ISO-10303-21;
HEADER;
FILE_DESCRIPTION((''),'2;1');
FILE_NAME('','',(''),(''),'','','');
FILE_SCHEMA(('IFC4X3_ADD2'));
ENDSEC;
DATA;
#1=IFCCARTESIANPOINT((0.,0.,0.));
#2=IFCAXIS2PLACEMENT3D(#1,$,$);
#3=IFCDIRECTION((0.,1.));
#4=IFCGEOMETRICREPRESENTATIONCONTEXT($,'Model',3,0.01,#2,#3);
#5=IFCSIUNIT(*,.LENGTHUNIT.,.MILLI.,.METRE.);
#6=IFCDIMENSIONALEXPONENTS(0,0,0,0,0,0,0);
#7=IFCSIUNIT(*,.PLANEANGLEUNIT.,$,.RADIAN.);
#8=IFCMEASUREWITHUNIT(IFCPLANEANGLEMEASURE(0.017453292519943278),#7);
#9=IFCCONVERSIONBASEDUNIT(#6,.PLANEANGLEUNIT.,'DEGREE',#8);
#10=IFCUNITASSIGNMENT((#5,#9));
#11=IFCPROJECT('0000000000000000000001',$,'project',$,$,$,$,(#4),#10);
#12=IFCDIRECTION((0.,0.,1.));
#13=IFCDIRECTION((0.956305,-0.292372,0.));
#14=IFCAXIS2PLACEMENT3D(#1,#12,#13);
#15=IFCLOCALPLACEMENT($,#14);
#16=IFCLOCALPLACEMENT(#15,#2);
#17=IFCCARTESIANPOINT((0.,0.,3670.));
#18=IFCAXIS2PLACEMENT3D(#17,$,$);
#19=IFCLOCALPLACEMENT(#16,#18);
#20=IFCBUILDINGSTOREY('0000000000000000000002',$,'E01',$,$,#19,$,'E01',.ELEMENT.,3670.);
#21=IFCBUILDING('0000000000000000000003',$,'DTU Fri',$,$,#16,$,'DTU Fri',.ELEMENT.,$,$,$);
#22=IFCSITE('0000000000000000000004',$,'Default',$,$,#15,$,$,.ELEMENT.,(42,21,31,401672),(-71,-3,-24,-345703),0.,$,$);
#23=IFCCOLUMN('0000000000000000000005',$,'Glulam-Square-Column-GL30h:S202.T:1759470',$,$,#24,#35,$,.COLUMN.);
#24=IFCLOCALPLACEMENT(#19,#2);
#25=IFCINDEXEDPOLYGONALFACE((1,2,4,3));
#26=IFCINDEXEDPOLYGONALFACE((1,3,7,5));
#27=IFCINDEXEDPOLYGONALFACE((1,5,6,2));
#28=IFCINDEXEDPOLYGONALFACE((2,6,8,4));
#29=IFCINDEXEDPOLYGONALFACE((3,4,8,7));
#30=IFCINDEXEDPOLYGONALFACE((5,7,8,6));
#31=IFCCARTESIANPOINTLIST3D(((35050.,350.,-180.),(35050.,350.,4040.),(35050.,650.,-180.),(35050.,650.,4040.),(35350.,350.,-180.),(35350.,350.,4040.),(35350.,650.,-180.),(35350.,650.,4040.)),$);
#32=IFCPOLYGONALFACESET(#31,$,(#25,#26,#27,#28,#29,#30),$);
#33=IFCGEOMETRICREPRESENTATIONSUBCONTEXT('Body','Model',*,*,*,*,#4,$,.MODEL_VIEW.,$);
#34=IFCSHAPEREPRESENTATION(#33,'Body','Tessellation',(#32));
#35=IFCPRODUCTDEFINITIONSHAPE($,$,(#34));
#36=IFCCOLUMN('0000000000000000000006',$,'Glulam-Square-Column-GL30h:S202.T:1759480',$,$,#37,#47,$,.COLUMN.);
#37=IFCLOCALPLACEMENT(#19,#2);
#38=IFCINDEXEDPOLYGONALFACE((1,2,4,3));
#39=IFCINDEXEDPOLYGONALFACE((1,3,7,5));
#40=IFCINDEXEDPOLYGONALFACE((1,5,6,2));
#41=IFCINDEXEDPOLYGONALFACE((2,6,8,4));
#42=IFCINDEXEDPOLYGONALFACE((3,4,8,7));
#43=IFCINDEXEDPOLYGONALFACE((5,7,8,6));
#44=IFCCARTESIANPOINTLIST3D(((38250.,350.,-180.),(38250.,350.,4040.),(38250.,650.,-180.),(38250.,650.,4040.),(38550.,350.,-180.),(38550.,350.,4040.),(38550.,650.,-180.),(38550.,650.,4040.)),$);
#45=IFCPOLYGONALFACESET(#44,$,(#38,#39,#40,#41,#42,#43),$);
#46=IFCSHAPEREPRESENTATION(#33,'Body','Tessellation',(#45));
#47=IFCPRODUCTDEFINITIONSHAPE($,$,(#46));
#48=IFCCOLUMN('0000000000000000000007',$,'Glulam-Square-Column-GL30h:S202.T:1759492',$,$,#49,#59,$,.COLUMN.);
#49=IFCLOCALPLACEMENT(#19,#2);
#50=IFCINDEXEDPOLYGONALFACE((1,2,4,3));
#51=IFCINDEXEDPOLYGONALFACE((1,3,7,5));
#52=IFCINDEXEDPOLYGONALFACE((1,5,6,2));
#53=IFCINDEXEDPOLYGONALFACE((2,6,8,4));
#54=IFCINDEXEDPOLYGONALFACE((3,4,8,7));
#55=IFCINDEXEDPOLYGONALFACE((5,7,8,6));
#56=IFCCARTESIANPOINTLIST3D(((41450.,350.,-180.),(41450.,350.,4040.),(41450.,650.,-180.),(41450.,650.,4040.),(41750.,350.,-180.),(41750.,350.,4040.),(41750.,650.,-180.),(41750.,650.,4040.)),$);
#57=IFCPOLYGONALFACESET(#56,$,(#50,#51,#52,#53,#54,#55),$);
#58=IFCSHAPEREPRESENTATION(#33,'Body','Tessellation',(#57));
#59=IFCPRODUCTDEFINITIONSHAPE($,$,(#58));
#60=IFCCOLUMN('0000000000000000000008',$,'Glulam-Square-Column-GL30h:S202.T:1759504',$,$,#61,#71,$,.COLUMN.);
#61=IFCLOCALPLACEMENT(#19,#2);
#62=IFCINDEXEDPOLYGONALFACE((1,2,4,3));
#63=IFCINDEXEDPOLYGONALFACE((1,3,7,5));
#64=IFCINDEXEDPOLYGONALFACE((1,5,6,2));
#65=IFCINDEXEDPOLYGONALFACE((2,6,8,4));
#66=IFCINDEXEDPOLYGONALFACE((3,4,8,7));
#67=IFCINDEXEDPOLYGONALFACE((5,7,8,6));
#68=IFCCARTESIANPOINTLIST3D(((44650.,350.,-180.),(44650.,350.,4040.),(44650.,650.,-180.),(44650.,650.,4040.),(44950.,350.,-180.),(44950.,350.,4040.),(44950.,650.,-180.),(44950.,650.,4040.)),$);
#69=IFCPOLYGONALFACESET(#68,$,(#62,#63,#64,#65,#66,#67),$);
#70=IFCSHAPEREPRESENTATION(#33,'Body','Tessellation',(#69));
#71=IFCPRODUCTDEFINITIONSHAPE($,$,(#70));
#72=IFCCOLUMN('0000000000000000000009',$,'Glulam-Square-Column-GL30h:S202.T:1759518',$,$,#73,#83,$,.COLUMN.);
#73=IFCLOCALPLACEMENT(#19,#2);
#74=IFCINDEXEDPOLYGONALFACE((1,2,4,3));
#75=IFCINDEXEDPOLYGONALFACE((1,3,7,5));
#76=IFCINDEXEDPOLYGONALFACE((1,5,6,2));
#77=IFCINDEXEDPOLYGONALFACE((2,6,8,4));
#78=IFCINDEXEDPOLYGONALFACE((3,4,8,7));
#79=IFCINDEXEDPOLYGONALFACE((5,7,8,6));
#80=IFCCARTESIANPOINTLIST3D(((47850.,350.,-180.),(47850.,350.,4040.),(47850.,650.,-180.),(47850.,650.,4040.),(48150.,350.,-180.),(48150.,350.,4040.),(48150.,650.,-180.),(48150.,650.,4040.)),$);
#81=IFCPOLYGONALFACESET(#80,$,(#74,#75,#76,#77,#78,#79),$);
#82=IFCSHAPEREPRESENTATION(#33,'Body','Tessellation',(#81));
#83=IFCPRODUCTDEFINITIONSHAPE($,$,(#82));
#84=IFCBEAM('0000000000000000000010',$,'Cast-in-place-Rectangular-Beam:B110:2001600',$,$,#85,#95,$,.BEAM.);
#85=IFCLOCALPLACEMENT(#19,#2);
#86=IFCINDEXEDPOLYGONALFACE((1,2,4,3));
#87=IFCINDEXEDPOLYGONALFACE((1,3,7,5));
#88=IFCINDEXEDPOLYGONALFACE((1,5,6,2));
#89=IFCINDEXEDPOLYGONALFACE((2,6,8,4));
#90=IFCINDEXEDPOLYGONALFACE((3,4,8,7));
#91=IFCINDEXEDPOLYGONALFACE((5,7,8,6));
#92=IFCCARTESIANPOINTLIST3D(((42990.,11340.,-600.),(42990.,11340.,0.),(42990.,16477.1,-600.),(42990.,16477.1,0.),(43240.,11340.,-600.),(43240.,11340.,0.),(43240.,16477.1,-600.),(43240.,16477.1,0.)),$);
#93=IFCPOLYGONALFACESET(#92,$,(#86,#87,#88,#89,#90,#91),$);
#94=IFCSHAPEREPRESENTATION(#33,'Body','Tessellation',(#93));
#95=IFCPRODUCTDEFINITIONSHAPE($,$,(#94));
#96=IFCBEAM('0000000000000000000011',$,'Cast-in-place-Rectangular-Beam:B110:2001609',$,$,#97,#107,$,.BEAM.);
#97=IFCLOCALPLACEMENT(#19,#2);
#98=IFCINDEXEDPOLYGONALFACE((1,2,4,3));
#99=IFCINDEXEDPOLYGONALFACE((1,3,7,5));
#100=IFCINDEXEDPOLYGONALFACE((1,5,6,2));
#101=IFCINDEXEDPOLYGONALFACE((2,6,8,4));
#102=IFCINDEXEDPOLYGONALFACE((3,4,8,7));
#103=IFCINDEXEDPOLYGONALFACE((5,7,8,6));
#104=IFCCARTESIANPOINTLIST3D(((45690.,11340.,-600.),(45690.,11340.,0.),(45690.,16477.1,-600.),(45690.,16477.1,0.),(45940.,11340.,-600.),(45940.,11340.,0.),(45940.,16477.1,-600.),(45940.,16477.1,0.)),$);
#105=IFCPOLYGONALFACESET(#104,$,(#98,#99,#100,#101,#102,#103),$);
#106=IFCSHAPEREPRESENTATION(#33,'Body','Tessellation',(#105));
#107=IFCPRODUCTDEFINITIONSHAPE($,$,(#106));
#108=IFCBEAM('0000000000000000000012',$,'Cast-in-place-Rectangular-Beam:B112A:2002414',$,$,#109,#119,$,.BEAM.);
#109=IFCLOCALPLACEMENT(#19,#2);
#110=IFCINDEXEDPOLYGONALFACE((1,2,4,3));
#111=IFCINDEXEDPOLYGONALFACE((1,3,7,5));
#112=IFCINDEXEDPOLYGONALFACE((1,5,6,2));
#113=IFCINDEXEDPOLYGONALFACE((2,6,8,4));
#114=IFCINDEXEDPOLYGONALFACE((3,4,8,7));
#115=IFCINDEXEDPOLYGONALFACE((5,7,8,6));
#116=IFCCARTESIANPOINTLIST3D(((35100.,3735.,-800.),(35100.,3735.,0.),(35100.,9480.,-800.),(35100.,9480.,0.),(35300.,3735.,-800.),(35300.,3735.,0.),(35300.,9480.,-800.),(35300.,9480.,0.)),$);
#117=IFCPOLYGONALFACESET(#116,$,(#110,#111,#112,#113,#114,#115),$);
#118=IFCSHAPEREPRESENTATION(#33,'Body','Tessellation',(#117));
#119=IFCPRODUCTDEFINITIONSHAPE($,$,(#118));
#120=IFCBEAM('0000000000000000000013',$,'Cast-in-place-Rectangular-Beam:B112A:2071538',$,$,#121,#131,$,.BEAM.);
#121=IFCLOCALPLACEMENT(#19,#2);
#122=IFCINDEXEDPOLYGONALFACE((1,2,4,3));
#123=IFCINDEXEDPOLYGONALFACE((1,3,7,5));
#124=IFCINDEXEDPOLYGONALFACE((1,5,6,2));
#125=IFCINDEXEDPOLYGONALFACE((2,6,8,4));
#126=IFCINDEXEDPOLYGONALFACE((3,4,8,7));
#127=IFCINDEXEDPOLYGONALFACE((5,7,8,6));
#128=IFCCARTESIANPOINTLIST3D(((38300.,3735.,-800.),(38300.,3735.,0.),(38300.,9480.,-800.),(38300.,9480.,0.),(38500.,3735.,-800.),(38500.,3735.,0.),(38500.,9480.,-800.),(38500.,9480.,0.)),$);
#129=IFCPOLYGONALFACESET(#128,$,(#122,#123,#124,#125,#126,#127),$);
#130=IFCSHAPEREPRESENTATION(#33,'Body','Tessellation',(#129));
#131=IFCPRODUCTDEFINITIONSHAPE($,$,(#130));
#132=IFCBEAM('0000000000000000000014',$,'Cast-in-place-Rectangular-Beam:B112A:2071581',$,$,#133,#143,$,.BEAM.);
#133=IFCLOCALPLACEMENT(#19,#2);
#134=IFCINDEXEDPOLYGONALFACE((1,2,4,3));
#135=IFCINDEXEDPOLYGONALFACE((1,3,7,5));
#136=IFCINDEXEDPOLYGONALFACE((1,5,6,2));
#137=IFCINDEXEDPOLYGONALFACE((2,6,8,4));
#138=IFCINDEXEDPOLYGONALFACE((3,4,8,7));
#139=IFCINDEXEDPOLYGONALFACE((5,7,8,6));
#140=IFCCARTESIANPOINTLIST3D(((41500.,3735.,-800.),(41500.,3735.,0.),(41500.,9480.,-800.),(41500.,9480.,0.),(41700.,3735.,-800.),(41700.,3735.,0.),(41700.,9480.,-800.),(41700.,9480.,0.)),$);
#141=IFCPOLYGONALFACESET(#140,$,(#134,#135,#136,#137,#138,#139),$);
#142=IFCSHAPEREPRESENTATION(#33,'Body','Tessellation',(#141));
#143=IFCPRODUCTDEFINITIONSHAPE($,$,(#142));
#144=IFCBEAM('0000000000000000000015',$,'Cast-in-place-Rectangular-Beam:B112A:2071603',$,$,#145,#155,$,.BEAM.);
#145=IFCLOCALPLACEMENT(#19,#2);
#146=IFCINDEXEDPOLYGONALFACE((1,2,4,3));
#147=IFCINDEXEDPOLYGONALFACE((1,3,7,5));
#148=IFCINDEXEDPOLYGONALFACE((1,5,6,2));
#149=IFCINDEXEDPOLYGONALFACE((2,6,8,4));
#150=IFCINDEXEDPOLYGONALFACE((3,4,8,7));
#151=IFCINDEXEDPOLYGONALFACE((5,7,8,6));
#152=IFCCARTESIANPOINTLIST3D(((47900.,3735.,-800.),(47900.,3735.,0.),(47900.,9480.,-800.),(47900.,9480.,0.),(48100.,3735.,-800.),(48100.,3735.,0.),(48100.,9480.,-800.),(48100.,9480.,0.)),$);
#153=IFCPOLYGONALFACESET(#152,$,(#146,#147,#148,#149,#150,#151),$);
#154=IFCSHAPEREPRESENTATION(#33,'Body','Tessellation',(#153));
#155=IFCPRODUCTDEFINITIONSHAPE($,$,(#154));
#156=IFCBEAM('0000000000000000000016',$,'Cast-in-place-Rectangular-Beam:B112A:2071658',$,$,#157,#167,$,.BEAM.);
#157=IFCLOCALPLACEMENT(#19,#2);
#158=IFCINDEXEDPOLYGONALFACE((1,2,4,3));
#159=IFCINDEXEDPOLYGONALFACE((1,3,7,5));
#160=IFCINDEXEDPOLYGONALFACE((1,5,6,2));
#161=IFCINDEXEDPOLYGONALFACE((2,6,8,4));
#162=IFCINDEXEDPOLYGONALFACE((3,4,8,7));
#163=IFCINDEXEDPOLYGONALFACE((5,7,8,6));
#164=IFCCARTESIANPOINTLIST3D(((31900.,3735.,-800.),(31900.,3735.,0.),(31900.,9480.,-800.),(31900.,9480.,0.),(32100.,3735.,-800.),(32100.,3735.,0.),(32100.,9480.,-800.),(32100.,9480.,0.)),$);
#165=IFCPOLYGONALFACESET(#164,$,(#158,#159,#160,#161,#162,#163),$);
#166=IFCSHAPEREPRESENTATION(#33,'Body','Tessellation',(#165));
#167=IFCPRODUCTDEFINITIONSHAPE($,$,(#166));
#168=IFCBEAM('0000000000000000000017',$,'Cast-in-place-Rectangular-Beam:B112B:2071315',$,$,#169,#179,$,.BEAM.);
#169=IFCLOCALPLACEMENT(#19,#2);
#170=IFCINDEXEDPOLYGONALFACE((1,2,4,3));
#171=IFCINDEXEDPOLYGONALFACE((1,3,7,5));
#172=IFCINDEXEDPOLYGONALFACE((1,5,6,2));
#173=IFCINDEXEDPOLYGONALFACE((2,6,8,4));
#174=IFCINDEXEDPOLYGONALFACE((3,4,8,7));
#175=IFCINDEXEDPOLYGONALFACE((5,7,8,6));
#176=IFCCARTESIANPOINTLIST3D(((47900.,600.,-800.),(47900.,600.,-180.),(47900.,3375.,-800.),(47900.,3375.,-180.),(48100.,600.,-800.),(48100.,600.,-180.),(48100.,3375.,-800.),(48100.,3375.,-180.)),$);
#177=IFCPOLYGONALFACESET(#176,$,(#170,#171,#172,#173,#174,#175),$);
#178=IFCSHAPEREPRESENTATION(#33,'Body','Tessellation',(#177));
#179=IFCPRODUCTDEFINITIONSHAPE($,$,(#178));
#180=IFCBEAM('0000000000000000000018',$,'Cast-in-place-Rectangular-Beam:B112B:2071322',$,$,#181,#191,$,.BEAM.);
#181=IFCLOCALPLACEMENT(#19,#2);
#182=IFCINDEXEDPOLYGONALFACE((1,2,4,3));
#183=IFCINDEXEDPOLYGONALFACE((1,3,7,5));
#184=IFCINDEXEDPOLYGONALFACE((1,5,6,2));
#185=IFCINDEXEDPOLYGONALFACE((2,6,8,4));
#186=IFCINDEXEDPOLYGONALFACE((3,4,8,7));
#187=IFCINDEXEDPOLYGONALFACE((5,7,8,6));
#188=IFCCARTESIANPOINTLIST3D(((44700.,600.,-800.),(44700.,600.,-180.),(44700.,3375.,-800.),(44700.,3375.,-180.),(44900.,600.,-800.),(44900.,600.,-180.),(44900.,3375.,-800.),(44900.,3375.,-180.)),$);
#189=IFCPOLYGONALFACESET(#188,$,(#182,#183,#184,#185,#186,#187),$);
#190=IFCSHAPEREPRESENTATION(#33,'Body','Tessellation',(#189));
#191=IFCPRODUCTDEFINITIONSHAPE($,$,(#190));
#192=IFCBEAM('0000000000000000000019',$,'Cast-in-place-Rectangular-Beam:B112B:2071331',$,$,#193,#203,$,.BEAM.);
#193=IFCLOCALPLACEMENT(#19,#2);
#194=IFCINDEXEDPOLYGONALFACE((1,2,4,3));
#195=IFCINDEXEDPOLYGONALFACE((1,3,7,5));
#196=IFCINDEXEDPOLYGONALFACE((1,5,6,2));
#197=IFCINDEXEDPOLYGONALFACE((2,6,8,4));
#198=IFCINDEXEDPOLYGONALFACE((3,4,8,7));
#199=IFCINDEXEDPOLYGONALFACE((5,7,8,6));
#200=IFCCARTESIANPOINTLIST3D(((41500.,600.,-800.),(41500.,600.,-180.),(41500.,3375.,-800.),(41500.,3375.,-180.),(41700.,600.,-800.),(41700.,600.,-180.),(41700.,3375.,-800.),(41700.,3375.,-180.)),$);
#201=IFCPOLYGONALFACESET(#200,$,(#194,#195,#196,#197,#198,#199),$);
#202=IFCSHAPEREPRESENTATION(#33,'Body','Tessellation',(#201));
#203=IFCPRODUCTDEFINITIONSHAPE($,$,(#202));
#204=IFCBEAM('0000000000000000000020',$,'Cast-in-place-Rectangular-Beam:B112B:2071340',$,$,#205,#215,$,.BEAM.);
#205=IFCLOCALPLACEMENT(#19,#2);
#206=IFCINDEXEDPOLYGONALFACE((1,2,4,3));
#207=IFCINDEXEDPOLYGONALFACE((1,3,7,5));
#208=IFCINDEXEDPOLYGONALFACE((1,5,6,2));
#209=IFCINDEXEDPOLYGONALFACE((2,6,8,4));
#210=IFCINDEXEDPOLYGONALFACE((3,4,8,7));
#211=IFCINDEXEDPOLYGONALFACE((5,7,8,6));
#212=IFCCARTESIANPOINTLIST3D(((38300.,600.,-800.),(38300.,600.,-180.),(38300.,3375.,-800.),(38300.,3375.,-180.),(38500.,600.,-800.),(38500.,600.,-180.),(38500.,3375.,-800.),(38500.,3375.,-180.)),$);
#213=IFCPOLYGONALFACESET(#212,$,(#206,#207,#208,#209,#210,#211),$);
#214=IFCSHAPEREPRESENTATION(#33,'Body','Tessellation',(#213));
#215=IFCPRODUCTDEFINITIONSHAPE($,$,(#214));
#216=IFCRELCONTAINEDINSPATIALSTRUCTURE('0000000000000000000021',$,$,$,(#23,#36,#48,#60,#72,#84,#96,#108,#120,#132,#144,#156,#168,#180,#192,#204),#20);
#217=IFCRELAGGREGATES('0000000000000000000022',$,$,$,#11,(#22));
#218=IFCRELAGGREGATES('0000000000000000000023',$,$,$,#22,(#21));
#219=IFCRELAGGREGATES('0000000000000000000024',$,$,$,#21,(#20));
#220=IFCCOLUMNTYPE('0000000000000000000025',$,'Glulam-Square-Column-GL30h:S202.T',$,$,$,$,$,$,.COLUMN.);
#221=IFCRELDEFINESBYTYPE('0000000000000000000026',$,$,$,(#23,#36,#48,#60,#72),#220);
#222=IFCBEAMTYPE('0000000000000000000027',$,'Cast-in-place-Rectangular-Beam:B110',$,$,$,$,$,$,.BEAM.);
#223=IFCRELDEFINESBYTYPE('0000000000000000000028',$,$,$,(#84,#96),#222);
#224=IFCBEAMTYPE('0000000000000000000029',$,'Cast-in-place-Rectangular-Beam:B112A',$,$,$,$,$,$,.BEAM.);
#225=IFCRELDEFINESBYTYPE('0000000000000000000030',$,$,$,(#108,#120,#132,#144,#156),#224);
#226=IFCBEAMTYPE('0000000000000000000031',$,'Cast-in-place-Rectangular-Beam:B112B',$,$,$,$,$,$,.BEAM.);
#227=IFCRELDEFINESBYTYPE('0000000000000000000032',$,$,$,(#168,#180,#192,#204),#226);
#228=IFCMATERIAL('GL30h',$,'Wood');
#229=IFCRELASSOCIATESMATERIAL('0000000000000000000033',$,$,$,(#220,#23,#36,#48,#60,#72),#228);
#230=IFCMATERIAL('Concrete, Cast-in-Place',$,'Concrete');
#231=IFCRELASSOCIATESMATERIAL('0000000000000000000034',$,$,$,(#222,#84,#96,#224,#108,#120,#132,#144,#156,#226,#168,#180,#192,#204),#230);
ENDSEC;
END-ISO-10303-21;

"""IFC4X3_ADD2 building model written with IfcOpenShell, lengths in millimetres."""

from ifc_helpers import new_model, entity, si_unit, converted_unit, direction, frame, origin, origin_2d_with_axis, place, context, subcontext, project, spatial, rectangle, extrude, source, transform, mapped, material, material_profile, profile_set, profile_usage, type_object, type_shapes, element, save


model = new_model("IFC4X3_ADD2")

# Units and contexts
model_context = context("Model", 3, precision=0.01, world=origin(), true_north=direction((0.0, 1.0)))
body_context = subcontext(model_context, "Body", "Model", "MODEL_VIEW")
ifc_project = project(units=[si_unit("LENGTHUNIT", "METRE", prefix="MILLI"), converted_unit("PLANEANGLEUNIT", "DEGREE", entity("IfcPlaneAngleMeasure", 0.017453292519943278), si_unit("PLANEANGLEUNIT", "RADIAN"), dimensions=[0, 0, 0, 0, 0, 0, 0])], contexts=[model_context])

# Site, building, storey
site_placement = place(None, frame((0.0, 0.0, 0.0), z_axis=(0.0, 0.0, 1.0), x_axis=(0.956305, -0.292372, 0.0)))
site = spatial("IfcSite", under=ifc_project, at=site_placement, Name="Default", CompositionType="ELEMENT", RefLatitude=(42, 21, 31, 401672), RefLongitude=(-71, -3, -24, -345703), RefElevation=0.0)
building_placement = place(site_placement, origin())
building = spatial("IfcBuilding", under=site, at=building_placement, Name="DTU Fri", LongName="DTU Fri", CompositionType="ELEMENT")
storey_placement = place(building_placement, frame((0.0, 0.0, 3670.0)))
storey = spatial("IfcBuildingStorey", under=building, at=storey_placement, Name="E01", LongName="E01", CompositionType="ELEMENT", Elevation=3670.0)

# Columns
ifc_material_1 = material(Name="GL30h", Category="Wood")
ifc_material_profile_1 = material_profile(ifc_material_1, rectangle(XDim=300.0, YDim=300.0, at=origin_2d_with_axis()), Name="S202.T")
ifc_profile_set_1 = profile_set([ifc_material_profile_1], Name="S202.T")
ifc_profile_usage_1 = profile_usage(ifc_profile_set_1)
column_type = type_object("IfcColumnType", Name="Glulam-Square-Column-GL30h:S202.T", PredefinedType="COLUMN", material=ifc_profile_set_1)
shared_shape_1 = source(origin(), body_context, "Body", "SweptSolid", [
    extrude(rectangle(XDim=300.0, YDim=300.0, at=origin_2d_with_axis()), frame((0.0, 0.0, 3490.0), z_axis=(0.0, 0.0, 1.0), x_axis=(0.0, 1.0, 0.0)), (0.0, 0.0, 1.0), 4220.0),
])
type_shapes(column_type, [shared_shape_1])
for number, where, name in (
    (1, (35200.0, 500.0, -3670.0), "Glulam-Square-Column-GL30h:S202.T:1759470"),
    (2, (38400.0, 500.0, -3670.0), "Glulam-Square-Column-GL30h:S202.T:1759480"),
    (3, (41600.0, 500.0, -3670.0), "Glulam-Square-Column-GL30h:S202.T:1759492"),
    (4, (44800.0, 500.0, -3670.0), "Glulam-Square-Column-GL30h:S202.T:1759504"),
    (5, (48000.0, 500.0, -3670.0), "Glulam-Square-Column-GL30h:S202.T:1759518"),
):
    element("IfcColumn", number, at=place(storey_placement, frame(where)), inside=storey, type_object=column_type, material=ifc_profile_usage_1, Name=name, PredefinedType="COLUMN", context=body_context, shape_type="MappedRepresentation", body=[
        mapped(shared_shape_1, transform((0.0, 0.0, 0.0), scale=1.0)),
    ])

# Beams
ifc_material_2 = material(Name="Concrete, Cast-in-Place", Category="Concrete")
ifc_material_profile_2 = material_profile(ifc_material_2, rectangle(XDim=600.0, YDim=250.0, at=origin_2d_with_axis()), Name="B110")
ifc_profile_set_2 = profile_set([ifc_material_profile_2], Name="B110")
ifc_profile_usage_2 = profile_usage(ifc_profile_set_2, cardinal=8)
beam_type_1 = type_object("IfcBeamType", Name="Cast-in-place-Rectangular-Beam:B110", PredefinedType="BEAM", material=ifc_profile_set_2)
shared_shape_2 = source(origin(), body_context, "Body", "SweptSolid", [
    extrude(rectangle(XDim=600.0, YDim=250.0, at=origin_2d_with_axis()), frame((-2536.0, 0.0, 0.0), z_axis=(1.0, 0.0, 0.0), x_axis=(0.0, 0.0, -1.0)), (0.0, 0.0, 1.0), 5137.1),
])
type_shapes(beam_type_1, [shared_shape_2])
for number, where, z_axis, x_axis, name in (
    (6, (43115.0, 13941.0, -300.0), (0.0, 0.0, 1.0), (0.0, -1.0, 0.0), "Cast-in-place-Rectangular-Beam:B110:2001600"),
    (7, (45815.0, 13941.0, -300.0), (0.0, 0.0, 1.0), (0.0, -1.0, 0.0), "Cast-in-place-Rectangular-Beam:B110:2001609"),
):
    element("IfcBeam", number, at=place(storey_placement, frame(where, z_axis=z_axis, x_axis=x_axis)), inside=storey, type_object=beam_type_1, material=ifc_profile_usage_2, Name=name, PredefinedType="BEAM", context=body_context, shape_type="MappedRepresentation", body=[
        mapped(shared_shape_2, transform((0.0, 0.0, 0.0), scale=1.0)),
    ])
ifc_material_profile_3 = material_profile(ifc_material_2, rectangle(XDim=800.0, YDim=200.0, at=origin_2d_with_axis()), Name="B112A")
ifc_profile_set_3 = profile_set([ifc_material_profile_3], Name="B112A")
ifc_profile_usage_3 = profile_usage(ifc_profile_set_3, cardinal=8)
beam_type_2 = type_object("IfcBeamType", Name="Cast-in-place-Rectangular-Beam:B112A", PredefinedType="BEAM", material=ifc_profile_set_3)
shared_shape_3 = source(origin(), body_context, "Body", "SweptSolid", [
    extrude(rectangle(XDim=800.0, YDim=200.0, at=origin_2d_with_axis()), frame((-2895.0, 0.0, 0.0), z_axis=(1.0, 0.0, 0.0), x_axis=(0.0, 0.0, -1.0)), (0.0, 0.0, 1.0), 5745.0),
])
type_shapes(beam_type_2, [shared_shape_3])
for number, where, z_axis, x_axis, name in (
    (8, (35200.0, 6585.0, -400.0), (0.0, 0.0, 1.0), (0.0, -1.0, 0.0), "Cast-in-place-Rectangular-Beam:B112A:2002414"),
    (9, (38400.0, 6585.0, -400.0), (0.0, 0.0, 1.0), (0.0, -1.0, 0.0), "Cast-in-place-Rectangular-Beam:B112A:2071538"),
    (10, (41600.0, 6585.0, -400.0), (0.0, 0.0, 1.0), (0.0, -1.0, 0.0), "Cast-in-place-Rectangular-Beam:B112A:2071581"),
    (11, (48000.0, 6585.0, -400.0), (0.0, 0.0, 1.0), (0.0, -1.0, 0.0), "Cast-in-place-Rectangular-Beam:B112A:2071603"),
    (12, (32000.0, 6585.0, -400.0), (0.0, 0.0, 1.0), (0.0, -1.0, 0.0), "Cast-in-place-Rectangular-Beam:B112A:2071658"),
):
    element("IfcBeam", number, at=place(storey_placement, frame(where, z_axis=z_axis, x_axis=x_axis)), inside=storey, type_object=beam_type_2, material=ifc_profile_usage_3, Name=name, PredefinedType="BEAM", context=body_context, shape_type="MappedRepresentation", body=[
        mapped(shared_shape_3, transform((0.0, 0.0, 0.0), scale=1.0)),
    ])
ifc_material_profile_4 = material_profile(ifc_material_2, rectangle(XDim=620.0, YDim=200.0, at=origin_2d_with_axis()), Name="B112B")
ifc_profile_set_4 = profile_set([ifc_material_profile_4], Name="B112B")
ifc_profile_usage_4 = profile_usage(ifc_profile_set_4, cardinal=8)
beam_type_3 = type_object("IfcBeamType", Name="Cast-in-place-Rectangular-Beam:B112B", PredefinedType="BEAM", material=ifc_profile_set_4)
shared_shape_4 = source(origin(), body_context, "Body", "SweptSolid", [
    extrude(rectangle(XDim=620.0, YDim=200.0, at=origin_2d_with_axis()), frame((-1347.5, 0.0, 0.0), z_axis=(1.0, 0.0, 0.0), x_axis=(0.0, 0.0, -1.0)), (0.0, 0.0, 1.0), 2775.0),
])
type_shapes(beam_type_3, [shared_shape_4])
for number, where, z_axis, x_axis, name in (
    (13, (48000.0, 2027.5, -490.0), (0.0, 0.0, 1.0), (0.0, -1.0, 0.0), "Cast-in-place-Rectangular-Beam:B112B:2071315"),
    (14, (44800.0, 2027.5, -490.0), (0.0, 0.0, 1.0), (0.0, -1.0, 0.0), "Cast-in-place-Rectangular-Beam:B112B:2071322"),
    (15, (41600.0, 2027.5, -490.0), (0.0, 0.0, 1.0), (0.0, -1.0, 0.0), "Cast-in-place-Rectangular-Beam:B112B:2071331"),
    (16, (38400.0, 2027.5, -490.0), (0.0, 0.0, 1.0), (0.0, -1.0, 0.0), "Cast-in-place-Rectangular-Beam:B112B:2071340"),
):
    element("IfcBeam", number, at=place(storey_placement, frame(where, z_axis=z_axis, x_axis=x_axis)), inside=storey, type_object=beam_type_3, material=ifc_profile_usage_4, Name=name, PredefinedType="BEAM", context=body_context, shape_type="MappedRepresentation", body=[
        mapped(shared_shape_4, transform((0.0, 0.0, 0.0), scale=1.0)),
    ])

save(model, "model.ifc")
